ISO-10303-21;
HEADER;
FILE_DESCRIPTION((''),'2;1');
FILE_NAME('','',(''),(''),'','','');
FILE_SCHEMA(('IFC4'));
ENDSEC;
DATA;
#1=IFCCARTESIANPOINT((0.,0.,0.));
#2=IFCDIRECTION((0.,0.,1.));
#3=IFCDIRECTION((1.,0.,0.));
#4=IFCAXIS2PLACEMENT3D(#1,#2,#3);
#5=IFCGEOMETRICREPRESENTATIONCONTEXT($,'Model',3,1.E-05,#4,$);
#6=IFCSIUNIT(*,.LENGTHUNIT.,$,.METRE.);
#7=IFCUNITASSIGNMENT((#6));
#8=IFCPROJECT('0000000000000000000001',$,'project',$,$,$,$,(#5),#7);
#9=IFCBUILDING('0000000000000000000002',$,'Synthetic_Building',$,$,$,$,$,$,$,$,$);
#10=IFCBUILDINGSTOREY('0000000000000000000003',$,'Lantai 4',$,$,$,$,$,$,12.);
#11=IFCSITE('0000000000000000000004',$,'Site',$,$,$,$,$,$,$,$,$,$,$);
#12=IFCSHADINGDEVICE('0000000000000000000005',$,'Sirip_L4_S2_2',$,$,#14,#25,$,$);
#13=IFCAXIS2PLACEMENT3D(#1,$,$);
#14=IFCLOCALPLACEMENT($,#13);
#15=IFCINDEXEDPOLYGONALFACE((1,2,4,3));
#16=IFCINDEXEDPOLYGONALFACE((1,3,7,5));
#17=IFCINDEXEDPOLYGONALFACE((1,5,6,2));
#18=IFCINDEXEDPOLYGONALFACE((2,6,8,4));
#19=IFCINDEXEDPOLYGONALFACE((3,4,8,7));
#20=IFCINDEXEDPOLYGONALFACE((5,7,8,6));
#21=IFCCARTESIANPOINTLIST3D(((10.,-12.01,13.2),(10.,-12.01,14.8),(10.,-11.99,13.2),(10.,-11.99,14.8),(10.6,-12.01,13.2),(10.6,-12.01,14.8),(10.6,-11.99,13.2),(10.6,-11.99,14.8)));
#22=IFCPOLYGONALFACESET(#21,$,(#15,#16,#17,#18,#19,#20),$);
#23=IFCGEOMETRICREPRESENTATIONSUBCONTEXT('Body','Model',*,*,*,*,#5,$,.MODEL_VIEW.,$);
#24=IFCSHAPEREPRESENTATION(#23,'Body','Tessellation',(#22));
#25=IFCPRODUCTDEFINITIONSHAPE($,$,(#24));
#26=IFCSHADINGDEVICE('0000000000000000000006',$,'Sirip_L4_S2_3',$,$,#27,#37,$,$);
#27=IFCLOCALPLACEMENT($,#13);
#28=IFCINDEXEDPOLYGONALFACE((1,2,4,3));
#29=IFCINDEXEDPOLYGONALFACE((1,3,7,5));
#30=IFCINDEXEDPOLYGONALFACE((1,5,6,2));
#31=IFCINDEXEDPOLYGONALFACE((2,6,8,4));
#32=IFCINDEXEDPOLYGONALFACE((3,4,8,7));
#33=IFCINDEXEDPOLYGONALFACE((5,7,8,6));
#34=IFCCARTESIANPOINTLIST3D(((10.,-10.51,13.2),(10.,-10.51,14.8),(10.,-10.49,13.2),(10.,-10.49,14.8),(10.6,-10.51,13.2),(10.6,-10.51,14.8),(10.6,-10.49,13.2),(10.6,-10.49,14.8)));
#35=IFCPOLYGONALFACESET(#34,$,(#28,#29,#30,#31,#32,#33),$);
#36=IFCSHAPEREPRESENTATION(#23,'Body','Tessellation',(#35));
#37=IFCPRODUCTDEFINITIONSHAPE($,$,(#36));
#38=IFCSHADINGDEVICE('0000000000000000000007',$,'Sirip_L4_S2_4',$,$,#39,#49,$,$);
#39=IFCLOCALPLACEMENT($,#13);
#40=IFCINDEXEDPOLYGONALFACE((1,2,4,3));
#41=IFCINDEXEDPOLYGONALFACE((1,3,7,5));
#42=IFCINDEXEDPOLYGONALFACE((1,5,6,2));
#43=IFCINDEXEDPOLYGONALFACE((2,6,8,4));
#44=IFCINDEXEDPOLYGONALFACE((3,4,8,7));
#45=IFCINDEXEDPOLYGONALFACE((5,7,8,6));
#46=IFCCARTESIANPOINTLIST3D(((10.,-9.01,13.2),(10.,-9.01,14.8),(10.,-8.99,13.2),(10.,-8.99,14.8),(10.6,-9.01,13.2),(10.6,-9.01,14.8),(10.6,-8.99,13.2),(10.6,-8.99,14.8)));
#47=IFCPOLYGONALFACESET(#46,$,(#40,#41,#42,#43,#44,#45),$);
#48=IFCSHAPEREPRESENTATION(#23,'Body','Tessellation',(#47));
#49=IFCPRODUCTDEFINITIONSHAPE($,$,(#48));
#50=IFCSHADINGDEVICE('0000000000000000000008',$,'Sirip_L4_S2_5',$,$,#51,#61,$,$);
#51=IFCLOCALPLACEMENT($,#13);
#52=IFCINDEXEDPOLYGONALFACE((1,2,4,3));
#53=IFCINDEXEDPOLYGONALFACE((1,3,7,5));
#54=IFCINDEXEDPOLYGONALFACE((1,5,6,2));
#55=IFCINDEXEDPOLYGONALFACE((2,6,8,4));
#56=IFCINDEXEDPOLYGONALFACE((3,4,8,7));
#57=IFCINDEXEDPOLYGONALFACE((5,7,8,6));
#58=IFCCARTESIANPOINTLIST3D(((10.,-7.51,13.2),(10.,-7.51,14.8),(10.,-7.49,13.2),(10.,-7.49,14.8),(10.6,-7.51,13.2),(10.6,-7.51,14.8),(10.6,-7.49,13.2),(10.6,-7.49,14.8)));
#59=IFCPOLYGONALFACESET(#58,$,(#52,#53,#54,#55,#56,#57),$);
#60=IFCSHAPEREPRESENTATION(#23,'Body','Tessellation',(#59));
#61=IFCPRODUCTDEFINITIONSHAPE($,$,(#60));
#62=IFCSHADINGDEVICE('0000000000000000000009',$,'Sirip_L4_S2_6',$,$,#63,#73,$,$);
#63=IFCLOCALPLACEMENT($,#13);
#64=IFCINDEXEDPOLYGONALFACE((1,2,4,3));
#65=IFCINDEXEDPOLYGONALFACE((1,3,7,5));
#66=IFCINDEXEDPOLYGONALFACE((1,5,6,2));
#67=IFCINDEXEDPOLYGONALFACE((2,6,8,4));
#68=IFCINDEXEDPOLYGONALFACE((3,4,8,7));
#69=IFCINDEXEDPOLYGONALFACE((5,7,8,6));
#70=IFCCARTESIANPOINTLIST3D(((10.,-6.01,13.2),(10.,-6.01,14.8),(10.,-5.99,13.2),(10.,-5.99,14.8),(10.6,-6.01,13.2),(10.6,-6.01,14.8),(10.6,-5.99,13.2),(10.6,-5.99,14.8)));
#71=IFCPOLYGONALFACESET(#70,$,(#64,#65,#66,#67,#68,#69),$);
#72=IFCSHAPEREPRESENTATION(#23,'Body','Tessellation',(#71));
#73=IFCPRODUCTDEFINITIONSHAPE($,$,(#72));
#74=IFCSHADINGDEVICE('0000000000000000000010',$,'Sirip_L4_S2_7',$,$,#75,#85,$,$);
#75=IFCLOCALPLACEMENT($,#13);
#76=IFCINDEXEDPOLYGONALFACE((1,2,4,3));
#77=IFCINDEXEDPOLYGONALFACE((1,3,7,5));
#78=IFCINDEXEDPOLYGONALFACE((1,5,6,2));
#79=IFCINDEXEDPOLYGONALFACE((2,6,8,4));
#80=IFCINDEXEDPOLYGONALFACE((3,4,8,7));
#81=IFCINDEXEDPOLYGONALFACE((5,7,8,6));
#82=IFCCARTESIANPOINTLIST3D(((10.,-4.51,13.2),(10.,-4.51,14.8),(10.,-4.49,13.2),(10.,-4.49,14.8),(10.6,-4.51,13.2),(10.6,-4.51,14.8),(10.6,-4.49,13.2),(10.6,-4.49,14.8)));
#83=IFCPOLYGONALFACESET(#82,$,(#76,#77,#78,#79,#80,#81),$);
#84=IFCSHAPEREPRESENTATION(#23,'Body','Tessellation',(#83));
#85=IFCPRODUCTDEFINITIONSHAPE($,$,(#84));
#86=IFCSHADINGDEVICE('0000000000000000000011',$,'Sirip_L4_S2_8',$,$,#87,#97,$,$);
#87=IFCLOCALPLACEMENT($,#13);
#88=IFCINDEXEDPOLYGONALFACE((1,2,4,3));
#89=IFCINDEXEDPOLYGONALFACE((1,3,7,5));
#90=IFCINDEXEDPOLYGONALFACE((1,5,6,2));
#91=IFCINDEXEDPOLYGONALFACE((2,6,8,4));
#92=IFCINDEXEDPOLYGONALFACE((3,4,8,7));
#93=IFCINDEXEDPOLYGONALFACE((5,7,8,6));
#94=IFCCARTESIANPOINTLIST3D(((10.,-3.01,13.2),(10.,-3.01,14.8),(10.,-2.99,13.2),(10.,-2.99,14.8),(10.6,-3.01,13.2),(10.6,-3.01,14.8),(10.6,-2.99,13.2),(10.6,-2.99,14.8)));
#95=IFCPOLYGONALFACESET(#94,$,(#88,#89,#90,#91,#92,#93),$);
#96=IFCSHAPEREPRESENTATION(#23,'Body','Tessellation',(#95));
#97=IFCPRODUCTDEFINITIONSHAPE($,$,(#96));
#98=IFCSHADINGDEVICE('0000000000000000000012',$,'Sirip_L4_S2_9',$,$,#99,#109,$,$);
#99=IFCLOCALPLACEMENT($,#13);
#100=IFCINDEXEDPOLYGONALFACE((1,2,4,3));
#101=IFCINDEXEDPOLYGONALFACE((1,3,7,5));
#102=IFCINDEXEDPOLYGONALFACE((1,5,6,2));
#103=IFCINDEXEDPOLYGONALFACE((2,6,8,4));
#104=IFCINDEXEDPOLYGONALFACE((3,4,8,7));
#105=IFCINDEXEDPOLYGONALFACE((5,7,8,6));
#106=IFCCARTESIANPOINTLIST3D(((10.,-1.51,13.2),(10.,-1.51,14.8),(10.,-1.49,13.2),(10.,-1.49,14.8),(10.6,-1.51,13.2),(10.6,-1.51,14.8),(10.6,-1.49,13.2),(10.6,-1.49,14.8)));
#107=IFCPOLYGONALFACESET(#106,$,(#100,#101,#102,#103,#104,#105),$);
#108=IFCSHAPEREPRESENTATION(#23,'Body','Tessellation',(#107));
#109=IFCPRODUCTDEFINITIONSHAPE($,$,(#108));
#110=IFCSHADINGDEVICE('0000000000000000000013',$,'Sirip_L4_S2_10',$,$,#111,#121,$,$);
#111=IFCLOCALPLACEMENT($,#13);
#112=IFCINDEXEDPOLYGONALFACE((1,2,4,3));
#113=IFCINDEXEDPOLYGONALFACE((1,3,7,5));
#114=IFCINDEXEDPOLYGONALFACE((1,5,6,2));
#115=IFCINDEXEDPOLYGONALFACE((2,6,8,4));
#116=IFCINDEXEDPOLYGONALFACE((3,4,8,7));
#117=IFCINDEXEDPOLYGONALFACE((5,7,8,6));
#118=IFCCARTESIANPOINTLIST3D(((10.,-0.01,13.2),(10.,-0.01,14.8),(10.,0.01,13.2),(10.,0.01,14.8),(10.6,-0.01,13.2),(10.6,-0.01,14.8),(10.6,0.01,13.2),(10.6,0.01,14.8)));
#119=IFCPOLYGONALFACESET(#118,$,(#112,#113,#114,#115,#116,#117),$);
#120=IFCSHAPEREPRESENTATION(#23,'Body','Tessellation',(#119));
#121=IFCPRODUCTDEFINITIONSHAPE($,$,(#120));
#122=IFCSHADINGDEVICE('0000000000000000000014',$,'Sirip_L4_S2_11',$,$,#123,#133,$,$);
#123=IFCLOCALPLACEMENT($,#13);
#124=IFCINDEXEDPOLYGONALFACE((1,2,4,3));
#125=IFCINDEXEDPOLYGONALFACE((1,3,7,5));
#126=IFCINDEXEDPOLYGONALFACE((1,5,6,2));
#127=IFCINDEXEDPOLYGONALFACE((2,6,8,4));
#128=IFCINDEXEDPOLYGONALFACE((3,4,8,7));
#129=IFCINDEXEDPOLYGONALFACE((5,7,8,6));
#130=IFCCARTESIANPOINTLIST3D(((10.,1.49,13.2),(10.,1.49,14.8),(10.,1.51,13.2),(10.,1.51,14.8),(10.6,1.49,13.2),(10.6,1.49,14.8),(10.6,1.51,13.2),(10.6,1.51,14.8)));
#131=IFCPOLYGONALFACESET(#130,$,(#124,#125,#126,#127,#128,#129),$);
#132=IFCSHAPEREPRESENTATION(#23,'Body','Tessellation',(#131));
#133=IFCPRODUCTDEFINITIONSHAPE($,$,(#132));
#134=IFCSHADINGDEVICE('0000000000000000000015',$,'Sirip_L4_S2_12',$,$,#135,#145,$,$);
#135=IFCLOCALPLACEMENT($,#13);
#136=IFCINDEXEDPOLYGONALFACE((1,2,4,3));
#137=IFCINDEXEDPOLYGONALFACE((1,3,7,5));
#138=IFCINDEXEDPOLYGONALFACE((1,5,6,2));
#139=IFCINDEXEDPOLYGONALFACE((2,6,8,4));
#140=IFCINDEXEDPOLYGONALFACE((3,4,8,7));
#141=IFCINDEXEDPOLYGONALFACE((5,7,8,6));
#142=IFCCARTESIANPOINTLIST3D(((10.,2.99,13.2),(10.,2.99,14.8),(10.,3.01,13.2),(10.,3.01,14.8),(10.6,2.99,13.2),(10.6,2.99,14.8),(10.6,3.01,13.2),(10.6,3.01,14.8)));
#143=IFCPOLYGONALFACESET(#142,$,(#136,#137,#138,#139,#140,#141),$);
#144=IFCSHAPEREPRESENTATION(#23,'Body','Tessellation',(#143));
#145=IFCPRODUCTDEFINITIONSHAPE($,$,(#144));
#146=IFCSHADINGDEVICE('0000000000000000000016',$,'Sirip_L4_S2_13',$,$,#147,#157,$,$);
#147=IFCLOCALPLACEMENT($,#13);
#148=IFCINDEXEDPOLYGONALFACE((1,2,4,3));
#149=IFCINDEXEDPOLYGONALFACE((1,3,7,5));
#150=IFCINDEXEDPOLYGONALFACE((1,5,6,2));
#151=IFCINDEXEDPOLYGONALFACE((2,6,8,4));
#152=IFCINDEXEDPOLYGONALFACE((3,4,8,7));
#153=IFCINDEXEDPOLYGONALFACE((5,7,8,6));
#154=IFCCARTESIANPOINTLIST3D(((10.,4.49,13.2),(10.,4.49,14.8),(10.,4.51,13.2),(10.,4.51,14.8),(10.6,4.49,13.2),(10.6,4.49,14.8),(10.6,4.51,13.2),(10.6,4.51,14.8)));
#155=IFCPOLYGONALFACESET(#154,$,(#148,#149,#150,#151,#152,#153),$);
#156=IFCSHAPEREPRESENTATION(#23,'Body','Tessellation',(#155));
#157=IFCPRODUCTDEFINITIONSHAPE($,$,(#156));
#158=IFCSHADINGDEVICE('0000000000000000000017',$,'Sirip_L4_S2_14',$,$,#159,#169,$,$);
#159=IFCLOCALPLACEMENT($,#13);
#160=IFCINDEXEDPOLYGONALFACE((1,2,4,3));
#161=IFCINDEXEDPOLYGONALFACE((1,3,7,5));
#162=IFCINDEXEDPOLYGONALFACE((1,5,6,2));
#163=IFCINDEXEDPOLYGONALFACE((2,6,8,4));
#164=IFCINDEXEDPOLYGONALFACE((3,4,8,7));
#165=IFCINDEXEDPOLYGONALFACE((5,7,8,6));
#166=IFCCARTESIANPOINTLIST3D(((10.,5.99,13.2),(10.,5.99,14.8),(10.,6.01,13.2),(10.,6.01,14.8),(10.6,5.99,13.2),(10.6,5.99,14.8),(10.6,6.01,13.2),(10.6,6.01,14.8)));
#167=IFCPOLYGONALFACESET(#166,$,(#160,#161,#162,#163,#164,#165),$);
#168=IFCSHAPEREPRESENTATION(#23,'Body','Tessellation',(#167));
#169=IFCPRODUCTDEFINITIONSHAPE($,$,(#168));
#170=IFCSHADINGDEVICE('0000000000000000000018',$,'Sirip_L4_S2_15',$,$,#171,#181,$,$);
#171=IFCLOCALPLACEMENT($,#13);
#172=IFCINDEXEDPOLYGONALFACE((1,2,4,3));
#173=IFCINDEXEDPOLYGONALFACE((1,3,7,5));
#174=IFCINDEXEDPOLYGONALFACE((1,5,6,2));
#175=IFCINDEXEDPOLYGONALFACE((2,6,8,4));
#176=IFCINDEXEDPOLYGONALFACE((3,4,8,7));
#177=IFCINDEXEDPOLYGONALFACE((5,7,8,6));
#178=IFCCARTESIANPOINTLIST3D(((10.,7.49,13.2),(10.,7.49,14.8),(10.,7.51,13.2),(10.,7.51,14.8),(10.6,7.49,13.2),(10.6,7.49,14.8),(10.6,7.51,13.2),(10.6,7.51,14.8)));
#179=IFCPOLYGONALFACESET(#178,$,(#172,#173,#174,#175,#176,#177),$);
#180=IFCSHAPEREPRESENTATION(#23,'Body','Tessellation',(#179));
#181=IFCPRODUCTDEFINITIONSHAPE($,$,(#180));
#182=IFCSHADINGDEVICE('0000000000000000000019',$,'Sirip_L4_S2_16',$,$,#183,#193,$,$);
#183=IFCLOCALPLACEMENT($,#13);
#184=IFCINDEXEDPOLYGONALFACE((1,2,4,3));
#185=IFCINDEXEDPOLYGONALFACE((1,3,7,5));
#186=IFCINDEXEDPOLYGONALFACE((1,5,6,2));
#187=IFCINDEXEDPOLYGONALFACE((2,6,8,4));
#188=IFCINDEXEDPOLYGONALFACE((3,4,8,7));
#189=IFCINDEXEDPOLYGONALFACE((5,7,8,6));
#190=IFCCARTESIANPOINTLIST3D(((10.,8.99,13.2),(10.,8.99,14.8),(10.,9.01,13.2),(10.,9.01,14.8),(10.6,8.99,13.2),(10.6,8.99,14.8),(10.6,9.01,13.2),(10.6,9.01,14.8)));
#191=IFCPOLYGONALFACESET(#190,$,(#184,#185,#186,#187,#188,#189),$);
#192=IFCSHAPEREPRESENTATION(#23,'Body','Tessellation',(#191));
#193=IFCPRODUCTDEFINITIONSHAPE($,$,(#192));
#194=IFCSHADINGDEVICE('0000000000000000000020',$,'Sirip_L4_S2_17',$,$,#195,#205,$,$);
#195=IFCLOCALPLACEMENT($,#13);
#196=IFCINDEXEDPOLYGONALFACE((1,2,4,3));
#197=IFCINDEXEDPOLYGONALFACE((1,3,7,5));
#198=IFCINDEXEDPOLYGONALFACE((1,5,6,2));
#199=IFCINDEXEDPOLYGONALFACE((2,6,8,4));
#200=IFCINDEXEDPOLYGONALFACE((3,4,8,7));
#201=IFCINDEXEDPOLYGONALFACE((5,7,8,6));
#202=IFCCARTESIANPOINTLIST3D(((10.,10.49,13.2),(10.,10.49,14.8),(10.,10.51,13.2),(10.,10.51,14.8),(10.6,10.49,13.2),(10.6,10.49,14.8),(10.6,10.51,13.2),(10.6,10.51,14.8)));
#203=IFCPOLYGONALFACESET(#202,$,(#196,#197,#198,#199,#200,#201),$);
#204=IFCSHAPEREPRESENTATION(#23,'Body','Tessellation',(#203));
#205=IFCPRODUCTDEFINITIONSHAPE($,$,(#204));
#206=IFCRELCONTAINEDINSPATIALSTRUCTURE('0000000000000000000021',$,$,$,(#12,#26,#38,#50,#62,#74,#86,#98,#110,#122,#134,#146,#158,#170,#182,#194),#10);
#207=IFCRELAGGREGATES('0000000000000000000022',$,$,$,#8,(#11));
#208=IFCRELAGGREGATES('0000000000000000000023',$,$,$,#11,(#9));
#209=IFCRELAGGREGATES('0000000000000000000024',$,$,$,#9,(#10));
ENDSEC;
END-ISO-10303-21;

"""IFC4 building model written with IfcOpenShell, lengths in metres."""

from ifc_helpers import new_model, si_unit, frame, origin_with_axes, place, context, subcontext, project, spatial, polyline, outline, extrude, element, save


model = new_model("IFC4")

# Units and contexts
model_context = context("Model", 3, precision=1e-05, world=origin_with_axes())
body_context = subcontext(model_context, "Body", "Model", "MODEL_VIEW")
ifc_project = project(units=[si_unit("LENGTHUNIT", "METRE")], contexts=[model_context])

# Site, building, storey
site = spatial("IfcSite", under=ifc_project, Name="Site")
building = spatial("IfcBuilding", under=site, Name="Synthetic_Building")
storey = spatial("IfcBuildingStorey", under=building, Name="Lantai 4", Elevation=12.0)

# Shading devices
shading_device_1_placement = place(None, origin_with_axes())
element("IfcShadingDevice", 1, at=shading_device_1_placement, inside=storey, Name="Sirip_L4_S2_2", context=body_context, shape_type="SweptSolid", body=[
    extrude(outline(polyline([(10.0, -12.01), (10.0, -11.99), (10.6, -11.99), (10.6, -12.01), (10.0, -12.01)])), frame((0.0, 0.0, 13.2), z_axis=(0.0, 0.0, 1.0), x_axis=(1.0, 0.0, 0.0)), (0.0, 0.0, 1.0), 1.6),
])
shading_device_2_placement = place(None, origin_with_axes())
element("IfcShadingDevice", 2, at=shading_device_2_placement, inside=storey, Name="Sirip_L4_S2_3", context=body_context, shape_type="SweptSolid", body=[
    extrude(outline(polyline([(10.0, -10.51), (10.0, -10.49), (10.6, -10.49), (10.6, -10.51), (10.0, -10.51)])), frame((0.0, 0.0, 13.2), z_axis=(0.0, 0.0, 1.0), x_axis=(1.0, 0.0, 0.0)), (0.0, 0.0, 1.0), 1.6),
])
shading_device_3_placement = place(None, origin_with_axes())
element("IfcShadingDevice", 3, at=shading_device_3_placement, inside=storey, Name="Sirip_L4_S2_4", context=body_context, shape_type="SweptSolid", body=[
    extrude(outline(polyline([(10.0, -9.01), (10.0, -8.99), (10.6, -8.99), (10.6, -9.01), (10.0, -9.01)])), frame((0.0, 0.0, 13.2), z_axis=(0.0, 0.0, 1.0), x_axis=(1.0, 0.0, 0.0)), (0.0, 0.0, 1.0), 1.6),
])
shading_device_4_placement = place(None, origin_with_axes())
element("IfcShadingDevice", 4, at=shading_device_4_placement, inside=storey, Name="Sirip_L4_S2_5", context=body_context, shape_type="SweptSolid", body=[
    extrude(outline(polyline([(10.0, -7.51), (10.0, -7.49), (10.6, -7.49), (10.6, -7.51), (10.0, -7.51)])), frame((0.0, 0.0, 13.2), z_axis=(0.0, 0.0, 1.0), x_axis=(1.0, 0.0, 0.0)), (0.0, 0.0, 1.0), 1.6),
])
shading_device_5_placement = place(None, origin_with_axes())
element("IfcShadingDevice", 5, at=shading_device_5_placement, inside=storey, Name="Sirip_L4_S2_6", context=body_context, shape_type="SweptSolid", body=[
    extrude(outline(polyline([(10.0, -6.01), (10.0, -5.99), (10.6, -5.99), (10.6, -6.01), (10.0, -6.01)])), frame((0.0, 0.0, 13.2), z_axis=(0.0, 0.0, 1.0), x_axis=(1.0, 0.0, 0.0)), (0.0, 0.0, 1.0), 1.6),
])
shading_device_6_placement = place(None, origin_with_axes())
element("IfcShadingDevice", 6, at=shading_device_6_placement, inside=storey, Name="Sirip_L4_S2_7", context=body_context, shape_type="SweptSolid", body=[
    extrude(outline(polyline([(10.0, -4.51), (10.0, -4.49), (10.6, -4.49), (10.6, -4.51), (10.0, -4.51)])), frame((0.0, 0.0, 13.2), z_axis=(0.0, 0.0, 1.0), x_axis=(1.0, 0.0, 0.0)), (0.0, 0.0, 1.0), 1.6),
])
shading_device_7_placement = place(None, origin_with_axes())
element("IfcShadingDevice", 7, at=shading_device_7_placement, inside=storey, Name="Sirip_L4_S2_8", context=body_context, shape_type="SweptSolid", body=[
    extrude(outline(polyline([(10.0, -3.01), (10.0, -2.99), (10.6, -2.99), (10.6, -3.01), (10.0, -3.01)])), frame((0.0, 0.0, 13.2), z_axis=(0.0, 0.0, 1.0), x_axis=(1.0, 0.0, 0.0)), (0.0, 0.0, 1.0), 1.6),
])
shading_device_8_placement = place(None, origin_with_axes())
element("IfcShadingDevice", 8, at=shading_device_8_placement, inside=storey, Name="Sirip_L4_S2_9", context=body_context, shape_type="SweptSolid", body=[
    extrude(outline(polyline([(10.0, -1.51), (10.0, -1.49), (10.6, -1.49), (10.6, -1.51), (10.0, -1.51)])), frame((0.0, 0.0, 13.2), z_axis=(0.0, 0.0, 1.0), x_axis=(1.0, 0.0, 0.0)), (0.0, 0.0, 1.0), 1.6),
])
shading_device_9_placement = place(None, origin_with_axes())
element("IfcShadingDevice", 9, at=shading_device_9_placement, inside=storey, Name="Sirip_L4_S2_10", context=body_context, shape_type="SweptSolid", body=[
    extrude(outline(polyline([(10.0, -0.01), (10.0, 0.01), (10.6, 0.01), (10.6, -0.01), (10.0, -0.01)])), frame((0.0, 0.0, 13.2), z_axis=(0.0, 0.0, 1.0), x_axis=(1.0, 0.0, 0.0)), (0.0, 0.0, 1.0), 1.6),
])
shading_device_10_placement = place(None, origin_with_axes())
element("IfcShadingDevice", 10, at=shading_device_10_placement, inside=storey, Name="Sirip_L4_S2_11", context=body_context, shape_type="SweptSolid", body=[
    extrude(outline(polyline([(10.0, 1.49), (10.0, 1.51), (10.6, 1.51), (10.6, 1.49), (10.0, 1.49)])), frame((0.0, 0.0, 13.2), z_axis=(0.0, 0.0, 1.0), x_axis=(1.0, 0.0, 0.0)), (0.0, 0.0, 1.0), 1.6),
])
shading_device_11_placement = place(None, origin_with_axes())
element("IfcShadingDevice", 11, at=shading_device_11_placement, inside=storey, Name="Sirip_L4_S2_12", context=body_context, shape_type="SweptSolid", body=[
    extrude(outline(polyline([(10.0, 2.99), (10.0, 3.01), (10.6, 3.01), (10.6, 2.99), (10.0, 2.99)])), frame((0.0, 0.0, 13.2), z_axis=(0.0, 0.0, 1.0), x_axis=(1.0, 0.0, 0.0)), (0.0, 0.0, 1.0), 1.6),
])
shading_device_12_placement = place(None, origin_with_axes())
element("IfcShadingDevice", 12, at=shading_device_12_placement, inside=storey, Name="Sirip_L4_S2_13", context=body_context, shape_type="SweptSolid", body=[
    extrude(outline(polyline([(10.0, 4.49), (10.0, 4.51), (10.6, 4.51), (10.6, 4.49), (10.0, 4.49)])), frame((0.0, 0.0, 13.2), z_axis=(0.0, 0.0, 1.0), x_axis=(1.0, 0.0, 0.0)), (0.0, 0.0, 1.0), 1.6),
])
shading_device_13_placement = place(None, origin_with_axes())
element("IfcShadingDevice", 13, at=shading_device_13_placement, inside=storey, Name="Sirip_L4_S2_14", context=body_context, shape_type="SweptSolid", body=[
    extrude(outline(polyline([(10.0, 5.99), (10.0, 6.01), (10.6, 6.01), (10.6, 5.99), (10.0, 5.99)])), frame((0.0, 0.0, 13.2), z_axis=(0.0, 0.0, 1.0), x_axis=(1.0, 0.0, 0.0)), (0.0, 0.0, 1.0), 1.6),
])
shading_device_14_placement = place(None, origin_with_axes())
element("IfcShadingDevice", 14, at=shading_device_14_placement, inside=storey, Name="Sirip_L4_S2_15", context=body_context, shape_type="SweptSolid", body=[
    extrude(outline(polyline([(10.0, 7.49), (10.0, 7.51), (10.6, 7.51), (10.6, 7.49), (10.0, 7.49)])), frame((0.0, 0.0, 13.2), z_axis=(0.0, 0.0, 1.0), x_axis=(1.0, 0.0, 0.0)), (0.0, 0.0, 1.0), 1.6),
])
shading_device_15_placement = place(None, origin_with_axes())
element("IfcShadingDevice", 15, at=shading_device_15_placement, inside=storey, Name="Sirip_L4_S2_16", context=body_context, shape_type="SweptSolid", body=[
    extrude(outline(polyline([(10.0, 8.99), (10.0, 9.01), (10.6, 9.01), (10.6, 8.99), (10.0, 8.99)])), frame((0.0, 0.0, 13.2), z_axis=(0.0, 0.0, 1.0), x_axis=(1.0, 0.0, 0.0)), (0.0, 0.0, 1.0), 1.6),
])
shading_device_16_placement = place(None, origin_with_axes())
element("IfcShadingDevice", 16, at=shading_device_16_placement, inside=storey, Name="Sirip_L4_S2_17", context=body_context, shape_type="SweptSolid", body=[
    extrude(outline(polyline([(10.0, 10.49), (10.0, 10.51), (10.6, 10.51), (10.6, 10.49), (10.0, 10.49)])), frame((0.0, 0.0, 13.2), z_axis=(0.0, 0.0, 1.0), x_axis=(1.0, 0.0, 0.0)), (0.0, 0.0, 1.0), 1.6),
])

save(model, "model.ifc")
